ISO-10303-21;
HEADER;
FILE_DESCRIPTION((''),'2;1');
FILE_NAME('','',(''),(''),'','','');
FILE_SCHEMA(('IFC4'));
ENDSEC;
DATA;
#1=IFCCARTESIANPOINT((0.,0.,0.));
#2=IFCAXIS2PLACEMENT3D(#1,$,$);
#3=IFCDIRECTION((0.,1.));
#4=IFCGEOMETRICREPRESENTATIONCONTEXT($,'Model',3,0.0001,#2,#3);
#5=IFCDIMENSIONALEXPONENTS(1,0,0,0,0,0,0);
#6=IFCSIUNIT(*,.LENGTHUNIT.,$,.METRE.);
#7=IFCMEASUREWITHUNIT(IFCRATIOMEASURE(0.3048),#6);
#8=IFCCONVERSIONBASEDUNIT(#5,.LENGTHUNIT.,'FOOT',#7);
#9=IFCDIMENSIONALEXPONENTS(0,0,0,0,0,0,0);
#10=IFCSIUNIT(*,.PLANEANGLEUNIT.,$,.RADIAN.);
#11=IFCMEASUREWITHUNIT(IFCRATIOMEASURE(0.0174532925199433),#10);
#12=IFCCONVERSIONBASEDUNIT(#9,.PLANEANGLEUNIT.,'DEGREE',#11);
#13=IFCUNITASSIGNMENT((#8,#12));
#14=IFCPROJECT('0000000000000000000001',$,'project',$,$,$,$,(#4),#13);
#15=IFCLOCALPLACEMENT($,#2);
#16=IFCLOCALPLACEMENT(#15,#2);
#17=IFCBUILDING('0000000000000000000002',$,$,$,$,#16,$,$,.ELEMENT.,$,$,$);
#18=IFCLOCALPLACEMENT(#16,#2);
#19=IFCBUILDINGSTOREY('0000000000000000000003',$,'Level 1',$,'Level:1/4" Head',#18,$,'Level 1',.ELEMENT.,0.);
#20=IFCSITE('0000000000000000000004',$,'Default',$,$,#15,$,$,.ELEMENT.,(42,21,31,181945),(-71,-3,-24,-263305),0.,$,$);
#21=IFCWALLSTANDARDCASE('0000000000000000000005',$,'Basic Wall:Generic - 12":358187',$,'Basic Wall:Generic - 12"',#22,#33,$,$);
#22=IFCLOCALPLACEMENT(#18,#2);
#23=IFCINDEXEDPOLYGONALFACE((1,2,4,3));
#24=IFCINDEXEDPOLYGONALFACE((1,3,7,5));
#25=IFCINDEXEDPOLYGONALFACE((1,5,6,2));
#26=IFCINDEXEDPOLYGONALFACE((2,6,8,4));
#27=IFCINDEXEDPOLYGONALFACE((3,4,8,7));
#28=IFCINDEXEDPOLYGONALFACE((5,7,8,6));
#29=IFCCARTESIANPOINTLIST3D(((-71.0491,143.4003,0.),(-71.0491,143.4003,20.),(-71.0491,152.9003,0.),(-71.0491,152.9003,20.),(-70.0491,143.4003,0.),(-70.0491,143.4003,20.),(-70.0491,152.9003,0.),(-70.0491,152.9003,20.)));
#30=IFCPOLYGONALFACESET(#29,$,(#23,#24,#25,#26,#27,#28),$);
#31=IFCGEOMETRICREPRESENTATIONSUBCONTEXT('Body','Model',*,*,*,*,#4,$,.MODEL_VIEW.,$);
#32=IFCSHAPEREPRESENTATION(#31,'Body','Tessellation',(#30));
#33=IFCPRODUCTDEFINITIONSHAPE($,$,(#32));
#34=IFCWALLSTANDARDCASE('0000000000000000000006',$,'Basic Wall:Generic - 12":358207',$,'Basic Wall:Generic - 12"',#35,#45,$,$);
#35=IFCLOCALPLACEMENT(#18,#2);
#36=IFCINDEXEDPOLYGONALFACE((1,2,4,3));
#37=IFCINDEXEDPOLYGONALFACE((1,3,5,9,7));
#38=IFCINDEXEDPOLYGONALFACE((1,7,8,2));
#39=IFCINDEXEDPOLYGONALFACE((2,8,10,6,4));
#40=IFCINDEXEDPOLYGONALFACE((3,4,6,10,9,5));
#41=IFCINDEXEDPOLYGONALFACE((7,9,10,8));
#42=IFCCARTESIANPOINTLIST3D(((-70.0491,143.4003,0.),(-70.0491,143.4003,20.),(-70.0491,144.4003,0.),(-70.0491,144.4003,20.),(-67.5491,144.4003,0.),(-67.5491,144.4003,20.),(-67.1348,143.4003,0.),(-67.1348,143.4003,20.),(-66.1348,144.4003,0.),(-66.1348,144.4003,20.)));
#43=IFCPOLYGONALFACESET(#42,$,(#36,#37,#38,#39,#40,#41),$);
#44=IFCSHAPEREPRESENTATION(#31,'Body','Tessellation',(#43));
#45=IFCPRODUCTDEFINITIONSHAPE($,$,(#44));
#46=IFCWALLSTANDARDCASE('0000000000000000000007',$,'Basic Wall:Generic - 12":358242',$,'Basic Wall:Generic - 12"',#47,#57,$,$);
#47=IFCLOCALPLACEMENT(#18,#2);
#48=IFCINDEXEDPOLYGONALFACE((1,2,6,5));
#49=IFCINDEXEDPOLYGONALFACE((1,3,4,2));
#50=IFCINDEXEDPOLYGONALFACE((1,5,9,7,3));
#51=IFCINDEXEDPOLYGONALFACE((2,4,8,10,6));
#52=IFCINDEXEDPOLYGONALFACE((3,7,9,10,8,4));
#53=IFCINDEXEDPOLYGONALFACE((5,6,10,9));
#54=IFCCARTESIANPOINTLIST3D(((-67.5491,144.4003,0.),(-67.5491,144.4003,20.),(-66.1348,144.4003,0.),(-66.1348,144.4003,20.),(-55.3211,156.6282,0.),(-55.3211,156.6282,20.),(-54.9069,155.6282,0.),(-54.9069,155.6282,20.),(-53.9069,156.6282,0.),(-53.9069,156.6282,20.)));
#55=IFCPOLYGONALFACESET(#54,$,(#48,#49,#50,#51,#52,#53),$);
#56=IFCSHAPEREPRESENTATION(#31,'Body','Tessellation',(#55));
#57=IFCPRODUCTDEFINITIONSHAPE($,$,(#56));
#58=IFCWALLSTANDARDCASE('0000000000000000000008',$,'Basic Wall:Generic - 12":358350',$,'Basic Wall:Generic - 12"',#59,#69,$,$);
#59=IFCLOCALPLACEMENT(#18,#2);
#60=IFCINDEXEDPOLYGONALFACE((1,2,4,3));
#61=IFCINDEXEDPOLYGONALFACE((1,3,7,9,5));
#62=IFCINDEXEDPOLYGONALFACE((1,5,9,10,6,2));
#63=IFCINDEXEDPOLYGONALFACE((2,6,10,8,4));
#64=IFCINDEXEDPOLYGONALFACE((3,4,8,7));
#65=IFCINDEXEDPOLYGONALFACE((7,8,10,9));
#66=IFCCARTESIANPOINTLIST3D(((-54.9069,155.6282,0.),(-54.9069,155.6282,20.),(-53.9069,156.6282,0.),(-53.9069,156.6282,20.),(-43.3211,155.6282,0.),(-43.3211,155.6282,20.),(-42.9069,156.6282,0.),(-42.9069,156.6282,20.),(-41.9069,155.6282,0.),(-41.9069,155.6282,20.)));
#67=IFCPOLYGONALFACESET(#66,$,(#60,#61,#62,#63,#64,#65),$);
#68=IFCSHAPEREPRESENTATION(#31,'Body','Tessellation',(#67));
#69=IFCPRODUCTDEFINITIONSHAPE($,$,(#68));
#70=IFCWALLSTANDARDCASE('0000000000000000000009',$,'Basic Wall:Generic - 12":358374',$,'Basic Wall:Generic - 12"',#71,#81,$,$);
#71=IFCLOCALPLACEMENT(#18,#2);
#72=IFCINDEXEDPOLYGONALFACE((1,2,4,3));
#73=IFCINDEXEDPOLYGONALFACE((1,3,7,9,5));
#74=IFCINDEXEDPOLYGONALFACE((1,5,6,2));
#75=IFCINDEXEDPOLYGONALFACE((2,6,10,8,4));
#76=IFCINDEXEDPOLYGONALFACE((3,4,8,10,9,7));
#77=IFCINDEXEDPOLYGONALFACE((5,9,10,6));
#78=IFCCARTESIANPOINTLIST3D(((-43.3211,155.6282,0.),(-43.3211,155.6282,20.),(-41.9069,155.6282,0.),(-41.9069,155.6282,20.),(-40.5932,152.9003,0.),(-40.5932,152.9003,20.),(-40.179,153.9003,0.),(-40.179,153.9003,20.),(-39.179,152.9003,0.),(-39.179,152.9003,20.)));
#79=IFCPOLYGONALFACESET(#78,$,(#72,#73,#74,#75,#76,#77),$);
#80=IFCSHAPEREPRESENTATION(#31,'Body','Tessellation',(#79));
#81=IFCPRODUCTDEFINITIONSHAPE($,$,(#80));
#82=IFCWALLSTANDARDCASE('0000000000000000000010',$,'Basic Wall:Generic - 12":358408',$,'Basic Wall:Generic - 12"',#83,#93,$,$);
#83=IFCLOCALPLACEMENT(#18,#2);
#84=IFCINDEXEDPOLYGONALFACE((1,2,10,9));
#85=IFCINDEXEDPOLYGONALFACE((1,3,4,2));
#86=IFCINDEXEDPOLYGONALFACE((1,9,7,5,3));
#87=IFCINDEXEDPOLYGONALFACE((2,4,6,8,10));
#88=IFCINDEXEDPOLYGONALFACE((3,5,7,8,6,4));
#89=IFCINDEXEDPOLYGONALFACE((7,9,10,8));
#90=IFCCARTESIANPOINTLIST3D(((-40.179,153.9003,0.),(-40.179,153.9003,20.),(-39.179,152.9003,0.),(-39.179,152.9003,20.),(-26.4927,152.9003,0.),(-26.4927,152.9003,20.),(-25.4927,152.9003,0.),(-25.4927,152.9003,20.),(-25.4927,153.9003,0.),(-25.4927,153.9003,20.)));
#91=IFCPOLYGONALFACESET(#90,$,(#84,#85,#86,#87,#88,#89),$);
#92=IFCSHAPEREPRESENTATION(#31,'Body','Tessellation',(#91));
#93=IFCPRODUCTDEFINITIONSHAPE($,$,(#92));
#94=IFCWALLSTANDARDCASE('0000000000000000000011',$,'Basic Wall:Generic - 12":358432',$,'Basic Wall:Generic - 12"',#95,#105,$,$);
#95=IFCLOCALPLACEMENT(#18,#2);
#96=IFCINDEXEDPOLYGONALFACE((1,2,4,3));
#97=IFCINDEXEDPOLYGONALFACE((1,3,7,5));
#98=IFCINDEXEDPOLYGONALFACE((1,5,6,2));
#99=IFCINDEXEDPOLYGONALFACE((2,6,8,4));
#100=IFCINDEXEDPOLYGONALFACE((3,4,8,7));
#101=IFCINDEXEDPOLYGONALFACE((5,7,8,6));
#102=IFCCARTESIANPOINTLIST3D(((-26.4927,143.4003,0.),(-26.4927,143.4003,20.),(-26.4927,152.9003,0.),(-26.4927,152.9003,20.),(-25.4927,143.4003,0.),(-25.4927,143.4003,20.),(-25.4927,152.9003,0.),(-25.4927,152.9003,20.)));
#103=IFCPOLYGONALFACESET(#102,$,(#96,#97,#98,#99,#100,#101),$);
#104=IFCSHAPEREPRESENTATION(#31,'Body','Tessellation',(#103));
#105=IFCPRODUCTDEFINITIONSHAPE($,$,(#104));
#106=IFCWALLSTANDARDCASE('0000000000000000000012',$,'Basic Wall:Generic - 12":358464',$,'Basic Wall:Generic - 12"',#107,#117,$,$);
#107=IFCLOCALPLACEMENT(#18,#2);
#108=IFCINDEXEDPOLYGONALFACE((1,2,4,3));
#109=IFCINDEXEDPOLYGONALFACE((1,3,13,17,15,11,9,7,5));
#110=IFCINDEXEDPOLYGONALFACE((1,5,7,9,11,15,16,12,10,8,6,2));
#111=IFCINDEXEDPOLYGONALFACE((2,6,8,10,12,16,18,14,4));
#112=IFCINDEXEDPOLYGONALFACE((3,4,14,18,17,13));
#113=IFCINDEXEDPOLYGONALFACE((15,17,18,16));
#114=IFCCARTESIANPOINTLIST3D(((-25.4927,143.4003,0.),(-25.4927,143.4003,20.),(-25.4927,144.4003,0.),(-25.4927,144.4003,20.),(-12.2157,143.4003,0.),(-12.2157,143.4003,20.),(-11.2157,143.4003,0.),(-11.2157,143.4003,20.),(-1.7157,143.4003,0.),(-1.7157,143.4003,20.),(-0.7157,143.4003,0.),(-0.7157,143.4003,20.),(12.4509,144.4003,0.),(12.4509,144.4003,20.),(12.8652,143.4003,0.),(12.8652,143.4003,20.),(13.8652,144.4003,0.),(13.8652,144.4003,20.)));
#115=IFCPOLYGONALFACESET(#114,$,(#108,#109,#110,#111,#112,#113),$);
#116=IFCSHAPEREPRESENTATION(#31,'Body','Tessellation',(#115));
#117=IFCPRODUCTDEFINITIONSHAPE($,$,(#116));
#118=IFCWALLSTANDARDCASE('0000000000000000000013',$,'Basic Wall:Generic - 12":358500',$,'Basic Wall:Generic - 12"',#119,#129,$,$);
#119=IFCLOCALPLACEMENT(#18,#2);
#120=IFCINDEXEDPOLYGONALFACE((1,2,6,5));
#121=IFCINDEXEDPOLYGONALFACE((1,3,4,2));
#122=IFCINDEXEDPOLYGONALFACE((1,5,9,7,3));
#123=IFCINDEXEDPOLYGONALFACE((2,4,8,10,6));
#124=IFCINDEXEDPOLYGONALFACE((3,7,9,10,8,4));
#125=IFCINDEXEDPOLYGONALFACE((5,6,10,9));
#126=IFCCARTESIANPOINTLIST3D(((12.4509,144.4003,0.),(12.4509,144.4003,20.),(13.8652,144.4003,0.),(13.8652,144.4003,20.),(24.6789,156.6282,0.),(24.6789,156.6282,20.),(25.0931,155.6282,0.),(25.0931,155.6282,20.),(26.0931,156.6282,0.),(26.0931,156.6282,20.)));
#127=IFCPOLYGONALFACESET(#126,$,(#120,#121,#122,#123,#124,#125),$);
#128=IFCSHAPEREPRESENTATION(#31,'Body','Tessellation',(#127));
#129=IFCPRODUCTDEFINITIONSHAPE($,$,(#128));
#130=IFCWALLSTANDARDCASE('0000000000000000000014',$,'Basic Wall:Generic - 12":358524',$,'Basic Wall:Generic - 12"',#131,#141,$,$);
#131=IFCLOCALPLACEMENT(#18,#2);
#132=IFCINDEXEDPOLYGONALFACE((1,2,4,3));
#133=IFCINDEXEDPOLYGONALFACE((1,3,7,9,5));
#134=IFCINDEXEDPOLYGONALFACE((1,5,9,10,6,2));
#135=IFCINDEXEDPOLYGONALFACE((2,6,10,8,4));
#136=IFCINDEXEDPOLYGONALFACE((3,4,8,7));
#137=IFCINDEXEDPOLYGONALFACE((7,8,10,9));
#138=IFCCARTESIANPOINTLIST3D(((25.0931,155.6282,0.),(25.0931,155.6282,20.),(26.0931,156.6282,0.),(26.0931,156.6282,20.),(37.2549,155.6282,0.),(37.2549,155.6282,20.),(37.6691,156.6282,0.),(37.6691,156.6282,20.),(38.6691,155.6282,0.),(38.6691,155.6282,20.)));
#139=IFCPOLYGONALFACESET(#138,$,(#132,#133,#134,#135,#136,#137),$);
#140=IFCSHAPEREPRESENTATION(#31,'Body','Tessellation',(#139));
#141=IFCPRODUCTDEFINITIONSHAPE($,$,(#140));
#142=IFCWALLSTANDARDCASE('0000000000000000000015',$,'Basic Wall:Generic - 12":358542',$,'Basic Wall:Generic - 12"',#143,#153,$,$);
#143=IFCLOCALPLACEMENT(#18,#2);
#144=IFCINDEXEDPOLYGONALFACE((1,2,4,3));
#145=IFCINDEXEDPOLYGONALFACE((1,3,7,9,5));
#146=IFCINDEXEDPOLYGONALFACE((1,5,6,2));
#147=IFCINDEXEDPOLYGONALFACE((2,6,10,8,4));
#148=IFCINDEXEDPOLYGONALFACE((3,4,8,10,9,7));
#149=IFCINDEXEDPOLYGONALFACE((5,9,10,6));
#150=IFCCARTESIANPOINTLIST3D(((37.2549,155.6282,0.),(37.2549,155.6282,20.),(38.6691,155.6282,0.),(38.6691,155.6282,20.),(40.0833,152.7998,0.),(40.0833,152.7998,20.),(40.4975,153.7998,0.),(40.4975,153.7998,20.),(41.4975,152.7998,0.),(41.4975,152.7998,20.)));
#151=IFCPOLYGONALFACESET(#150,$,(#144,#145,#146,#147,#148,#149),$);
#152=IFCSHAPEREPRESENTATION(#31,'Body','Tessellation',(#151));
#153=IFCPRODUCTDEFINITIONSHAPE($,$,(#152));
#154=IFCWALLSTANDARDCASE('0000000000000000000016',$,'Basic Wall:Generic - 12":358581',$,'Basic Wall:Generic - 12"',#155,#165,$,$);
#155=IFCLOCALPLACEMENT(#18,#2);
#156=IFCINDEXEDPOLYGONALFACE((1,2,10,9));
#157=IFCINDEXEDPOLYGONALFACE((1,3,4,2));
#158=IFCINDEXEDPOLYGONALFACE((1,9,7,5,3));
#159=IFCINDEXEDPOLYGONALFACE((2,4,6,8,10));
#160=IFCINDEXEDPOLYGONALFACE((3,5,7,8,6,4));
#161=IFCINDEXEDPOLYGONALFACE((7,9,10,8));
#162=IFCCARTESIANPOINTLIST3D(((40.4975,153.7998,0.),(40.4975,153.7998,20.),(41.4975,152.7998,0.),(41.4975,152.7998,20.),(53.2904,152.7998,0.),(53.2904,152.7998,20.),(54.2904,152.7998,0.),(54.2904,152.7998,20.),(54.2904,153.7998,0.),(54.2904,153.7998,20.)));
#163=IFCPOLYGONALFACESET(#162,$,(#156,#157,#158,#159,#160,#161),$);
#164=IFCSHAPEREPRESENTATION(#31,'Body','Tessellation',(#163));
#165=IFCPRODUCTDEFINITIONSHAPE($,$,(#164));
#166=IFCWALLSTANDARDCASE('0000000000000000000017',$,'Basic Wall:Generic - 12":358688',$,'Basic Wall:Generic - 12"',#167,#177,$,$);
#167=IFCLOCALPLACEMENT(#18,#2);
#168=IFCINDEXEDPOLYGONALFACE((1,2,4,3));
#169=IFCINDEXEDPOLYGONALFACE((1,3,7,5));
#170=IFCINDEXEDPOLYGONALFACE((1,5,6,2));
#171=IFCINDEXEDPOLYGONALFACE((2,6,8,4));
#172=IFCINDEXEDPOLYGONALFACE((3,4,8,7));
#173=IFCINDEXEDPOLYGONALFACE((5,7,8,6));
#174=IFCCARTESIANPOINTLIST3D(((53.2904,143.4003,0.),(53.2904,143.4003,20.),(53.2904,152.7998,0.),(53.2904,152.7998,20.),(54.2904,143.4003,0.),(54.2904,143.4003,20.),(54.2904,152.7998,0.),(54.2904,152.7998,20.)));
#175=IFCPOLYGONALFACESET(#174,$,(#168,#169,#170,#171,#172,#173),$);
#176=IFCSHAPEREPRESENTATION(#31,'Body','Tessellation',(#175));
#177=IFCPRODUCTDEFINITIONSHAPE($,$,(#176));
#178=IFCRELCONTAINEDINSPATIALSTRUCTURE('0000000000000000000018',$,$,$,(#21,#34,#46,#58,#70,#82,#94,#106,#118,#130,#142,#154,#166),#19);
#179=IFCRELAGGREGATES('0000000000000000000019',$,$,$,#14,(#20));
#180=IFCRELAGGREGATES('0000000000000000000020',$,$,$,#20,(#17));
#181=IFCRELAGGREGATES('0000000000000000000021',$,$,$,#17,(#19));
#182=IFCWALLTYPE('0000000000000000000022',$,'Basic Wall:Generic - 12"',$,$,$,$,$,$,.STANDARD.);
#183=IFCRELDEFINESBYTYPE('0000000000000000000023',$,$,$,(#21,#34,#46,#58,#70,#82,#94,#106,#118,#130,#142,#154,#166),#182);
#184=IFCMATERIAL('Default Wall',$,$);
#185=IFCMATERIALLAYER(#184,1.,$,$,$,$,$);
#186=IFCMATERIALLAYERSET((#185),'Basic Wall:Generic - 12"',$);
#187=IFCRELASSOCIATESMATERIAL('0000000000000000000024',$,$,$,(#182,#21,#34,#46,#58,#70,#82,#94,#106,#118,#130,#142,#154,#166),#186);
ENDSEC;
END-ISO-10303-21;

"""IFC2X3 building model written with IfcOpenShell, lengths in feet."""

from ifc_helpers import new_model, entity, si_unit, converted_unit, direction, frame, frame_2d, origin, place, context, subcontext, project, spatial, polyline, rectangle, outline, extrude, material, layer, layer_set, layer_usage, type_object, element, save


model = new_model("IFC2X3")

# Units and contexts
model_context = context("Model", 3, precision=0.0001, world=origin(), true_north=direction((0.0, 1.0)))
body_context = subcontext(model_context, "Body", "Model", "MODEL_VIEW")
ifc_project = project(units=[converted_unit("LENGTHUNIT", "FOOT", entity("IfcRatioMeasure", 0.3048), si_unit("LENGTHUNIT", "METRE"), dimensions=[1, 0, 0, 0, 0, 0, 0]), converted_unit("PLANEANGLEUNIT", "DEGREE", entity("IfcRatioMeasure", 0.0174532925199433), si_unit("PLANEANGLEUNIT", "RADIAN"), dimensions=[0, 0, 0, 0, 0, 0, 0])], contexts=[model_context])

# Site, building, storey
site_placement = place(None, origin())
site = spatial("IfcSite", under=ifc_project, at=site_placement, Name="Default", CompositionType="ELEMENT", RefLatitude=(42, 21, 31, 181945), RefLongitude=(-71, -3, -24, -263305), RefElevation=0.0)
building_placement = place(site_placement, origin())
building = spatial("IfcBuilding", under=site, at=building_placement, CompositionType="ELEMENT")
storey_placement = place(building_placement, origin())
storey = spatial("IfcBuildingStorey", under=building, at=storey_placement, Name="Level 1", ObjectType="Level:1/4\" Head", LongName="Level 1", CompositionType="ELEMENT", Elevation=0.0)

# Walls
ifc_material = material(Name="Default Wall")
ifc_layer_1 = layer(ifc_material, 1.0)
ifc_layer_set_1 = layer_set([ifc_layer_1], Name="Basic Wall:Generic - 12\"")
ifc_layer_usage_1 = layer_usage(ifc_layer_set_1, "AXIS2", "NEGATIVE", 0.5)
wall_type_1 = type_object("IfcWallType", Name="Basic Wall:Generic - 12\"", PredefinedType="STANDARD", material=ifc_layer_set_1)
wall_1_placement = place(storey_placement, frame((-70.5491, 152.9003, 0.0), z_axis=(0.0, 0.0, 1.0), x_axis=(0.0, -1.0, 0.0)))
element("IfcWallStandardCase", 1, at=wall_1_placement, inside=storey, type_object=wall_type_1, material=ifc_layer_usage_1, Name="Basic Wall:Generic - 12\":358187", ObjectType="Basic Wall:Generic - 12\"", context=body_context, shape_type="SweptSolid", body=[
    extrude(rectangle(XDim=9.5, YDim=1.0, at=frame_2d((4.75, 0.0), x_axis=(-1.0, 0.0))), origin(), (0.0, 0.0, 1.0), 20.0),
])
ifc_layer_usage_2 = layer_usage(ifc_layer_set_1, "AXIS2", "NEGATIVE", 0.5)
wall_2_placement = place(storey_placement, frame((-70.0491, 143.9003, 0.0)))
element("IfcWallStandardCase", 2, at=wall_2_placement, inside=storey, type_object=wall_type_1, material=ifc_layer_usage_2, Name="Basic Wall:Generic - 12\":358207", ObjectType="Basic Wall:Generic - 12\"", context=body_context, shape_type="SweptSolid", body=[
    extrude(outline(polyline([(2.9142, -0.5), (3.9142, 0.5), (2.5, 0.5), (0.0, 0.5), (0.0, -0.5), (2.9142, -0.5)])), origin(), (0.0, 0.0, 1.0), 20.0),
])
ifc_layer_usage_3 = layer_usage(ifc_layer_set_1, "AXIS2", "NEGATIVE", 0.5)
wall_3_placement = place(storey_placement, frame((-67.1955, 144.0467, 0.0), z_axis=(0.0, 0.0, 1.0), x_axis=(0.707107, 0.707107, 0.0)))
element("IfcWallStandardCase", 3, at=wall_3_placement, inside=storey, type_object=wall_type_1, material=ifc_layer_usage_3, Name="Basic Wall:Generic - 12\":358242", ObjectType="Basic Wall:Generic - 12\"", context=body_context, shape_type="SweptSolid", body=[
    extrude(outline(polyline([(18.2929, -0.5), (17.2929, 0.5), (0.0, 0.5), (1.0, -0.5), (16.8787, -0.5), (18.2929, -0.5)])), origin(), (0.0, 0.0, 1.0), 20.0),
])
ifc_layer_usage_4 = layer_usage(ifc_layer_set_1, "AXIS2", "NEGATIVE", 0.5)
wall_4_placement = place(storey_placement, frame((-54.9069, 156.1282, 0.0)))
element("IfcWallStandardCase", 4, at=wall_4_placement, inside=storey, type_object=wall_type_1, material=ifc_layer_usage_4, Name="Basic Wall:Generic - 12\":358350", ObjectType="Basic Wall:Generic - 12\"", context=body_context, shape_type="SweptSolid", body=[
    extrude(outline(polyline([(13.0, -0.5), (12.0, 0.5), (1.0, 0.5), (0.0, -0.5), (11.5858, -0.5), (13.0, -0.5)])), origin(), (0.0, 0.0, 1.0), 20.0),
])
ifc_layer_usage_5 = layer_usage(ifc_layer_set_1, "AXIS2", "NEGATIVE", 0.5)
wall_5_placement = place(storey_placement, frame((-42.9676, 155.9818, 0.0), z_axis=(0.0, 0.0, 1.0), x_axis=(0.707107, -0.707107, 0.0)))
element("IfcWallStandardCase", 5, at=wall_5_placement, inside=storey, type_object=wall_type_1, material=ifc_layer_usage_5, Name="Basic Wall:Generic - 12\":358374", ObjectType="Basic Wall:Generic - 12\"", context=body_context, shape_type="SweptSolid", body=[
    extrude(outline(polyline([(3.8579, -0.5), (4.8579, 0.5), (3.4437, 0.5), (1.0, 0.5), (0.0, -0.5), (3.8579, -0.5)])), origin(), (0.0, 0.0, 1.0), 20.0),
])
ifc_layer_usage_6 = layer_usage(ifc_layer_set_1, "AXIS2", "NEGATIVE", 0.5)
wall_6_placement = place(storey_placement, frame((-40.179, 153.4003, 0.0)))
element("IfcWallStandardCase", 6, at=wall_6_placement, inside=storey, type_object=wall_type_1, material=ifc_layer_usage_6, Name="Basic Wall:Generic - 12\":358408", ObjectType="Basic Wall:Generic - 12\"", context=body_context, shape_type="SweptSolid", body=[
    extrude(outline(polyline([(14.6863, -0.5), (14.6863, 0.5), (0.0, 0.5), (1.0, -0.5), (13.6863, -0.5), (14.6863, -0.5)])), origin(), (0.0, 0.0, 1.0), 20.0),
])
ifc_layer_usage_7 = layer_usage(ifc_layer_set_1, "AXIS2", "NEGATIVE", 0.5)
wall_7_placement = place(storey_placement, frame((-25.9927, 152.9003, 0.0), z_axis=(0.0, 0.0, 1.0), x_axis=(0.0, -1.0, 0.0)))
element("IfcWallStandardCase", 7, at=wall_7_placement, inside=storey, type_object=wall_type_1, material=ifc_layer_usage_7, Name="Basic Wall:Generic - 12\":358432", ObjectType="Basic Wall:Generic - 12\"", context=body_context, shape_type="SweptSolid", body=[
    extrude(rectangle(XDim=9.5, YDim=1.0, at=frame_2d((4.75, 0.0), x_axis=(-1.0, 0.0))), origin(), (0.0, 0.0, 1.0), 20.0),
])
ifc_layer_usage_8 = layer_usage(ifc_layer_set_1, "AXIS2", "NEGATIVE", 0.5)
wall_8_placement = place(storey_placement, frame((-25.4927, 143.9003, 0.0)))
element("IfcWallStandardCase", 8, at=wall_8_placement, inside=storey, type_object=wall_type_1, material=ifc_layer_usage_8, Name="Basic Wall:Generic - 12\":358464", ObjectType="Basic Wall:Generic - 12\"", context=body_context, shape_type="SweptSolid", body=[
    extrude(outline(polyline([(38.3578, -0.5), (39.3578, 0.5), (37.9436, 0.5), (0.0, 0.5), (0.0, -0.5), (13.2769, -0.5), (14.2769, -0.5), (23.7769, -0.5), (24.7769, -0.5), (38.3578, -0.5)])), origin(), (0.0, 0.0, 1.0), 20.0),
])
ifc_layer_usage_9 = layer_usage(ifc_layer_set_1, "AXIS2", "NEGATIVE", 0.5)
wall_9_placement = place(storey_placement, frame((12.8045, 144.0467, 0.0), z_axis=(0.0, 0.0, 1.0), x_axis=(0.707107, 0.707107, 0.0)))
element("IfcWallStandardCase", 9, at=wall_9_placement, inside=storey, type_object=wall_type_1, material=ifc_layer_usage_9, Name="Basic Wall:Generic - 12\":358500", ObjectType="Basic Wall:Generic - 12\"", context=body_context, shape_type="SweptSolid", body=[
    extrude(outline(polyline([(18.2929, -0.5), (17.2929, 0.5), (0.0, 0.5), (1.0, -0.5), (16.8787, -0.5), (18.2929, -0.5)])), origin(), (0.0, 0.0, 1.0), 20.0),
])
ifc_layer_usage_10 = layer_usage(ifc_layer_set_1, "AXIS2", "NEGATIVE", 0.5)
wall_10_placement = place(storey_placement, frame((25.0931, 156.1282, 0.0)))
element("IfcWallStandardCase", 10, at=wall_10_placement, inside=storey, type_object=wall_type_1, material=ifc_layer_usage_10, Name="Basic Wall:Generic - 12\":358524", ObjectType="Basic Wall:Generic - 12\"", context=body_context, shape_type="SweptSolid", body=[
    extrude(outline(polyline([(13.576, -0.5), (12.576, 0.5), (1.0, 0.5), (0.0, -0.5), (12.1618, -0.5), (13.576, -0.5)])), origin(), (0.0, 0.0, 1.0), 20.0),
])
ifc_layer_usage_11 = layer_usage(ifc_layer_set_1, "AXIS2", "NEGATIVE", 0.5)
wall_11_placement = place(storey_placement, frame((37.6085, 155.9818, 0.0), z_axis=(0.0, 0.0, 1.0), x_axis=(0.707107, -0.707107, 0.0)))
element("IfcWallStandardCase", 11, at=wall_11_placement, inside=storey, type_object=wall_type_1, material=ifc_layer_usage_11, Name="Basic Wall:Generic - 12\":358542", ObjectType="Basic Wall:Generic - 12\"", context=body_context, shape_type="SweptSolid", body=[
    extrude(outline(polyline([(4.0, -0.5), (5.0, 0.5), (3.5858, 0.5), (1.0, 0.5), (0.0, -0.5), (4.0, -0.5)])), origin(), (0.0, 0.0, 1.0), 20.0),
])
ifc_layer_usage_12 = layer_usage(ifc_layer_set_1, "AXIS2", "NEGATIVE", 0.5)
wall_12_placement = place(storey_placement, frame((40.4975, 153.2998, 0.0)))
element("IfcWallStandardCase", 12, at=wall_12_placement, inside=storey, type_object=wall_type_1, material=ifc_layer_usage_12, Name="Basic Wall:Generic - 12\":358581", ObjectType="Basic Wall:Generic - 12\"", context=body_context, shape_type="SweptSolid", body=[
    extrude(outline(polyline([(13.7929, -0.5), (13.7929, 0.5), (0.0, 0.5), (1.0, -0.5), (12.7929, -0.5), (13.7929, -0.5)])), origin(), (0.0, 0.0, 1.0), 20.0),
])
ifc_layer_usage_13 = layer_usage(ifc_layer_set_1, "AXIS2", "NEGATIVE", 0.5)
wall_13_placement = place(storey_placement, frame((53.7904, 152.7998, 0.0), z_axis=(0.0, 0.0, 1.0), x_axis=(0.0, -1.0, 0.0)))
element("IfcWallStandardCase", 13, at=wall_13_placement, inside=storey, type_object=wall_type_1, material=ifc_layer_usage_13, Name="Basic Wall:Generic - 12\":358688", ObjectType="Basic Wall:Generic - 12\"", context=body_context, shape_type="SweptSolid", body=[
    extrude(rectangle(XDim=9.3995, YDim=1.0, at=frame_2d((4.6998, 0.0), x_axis=(-1.0, 0.0))), origin(), (0.0, 0.0, 1.0), 20.0),
])

save(model, "model.ifc")
